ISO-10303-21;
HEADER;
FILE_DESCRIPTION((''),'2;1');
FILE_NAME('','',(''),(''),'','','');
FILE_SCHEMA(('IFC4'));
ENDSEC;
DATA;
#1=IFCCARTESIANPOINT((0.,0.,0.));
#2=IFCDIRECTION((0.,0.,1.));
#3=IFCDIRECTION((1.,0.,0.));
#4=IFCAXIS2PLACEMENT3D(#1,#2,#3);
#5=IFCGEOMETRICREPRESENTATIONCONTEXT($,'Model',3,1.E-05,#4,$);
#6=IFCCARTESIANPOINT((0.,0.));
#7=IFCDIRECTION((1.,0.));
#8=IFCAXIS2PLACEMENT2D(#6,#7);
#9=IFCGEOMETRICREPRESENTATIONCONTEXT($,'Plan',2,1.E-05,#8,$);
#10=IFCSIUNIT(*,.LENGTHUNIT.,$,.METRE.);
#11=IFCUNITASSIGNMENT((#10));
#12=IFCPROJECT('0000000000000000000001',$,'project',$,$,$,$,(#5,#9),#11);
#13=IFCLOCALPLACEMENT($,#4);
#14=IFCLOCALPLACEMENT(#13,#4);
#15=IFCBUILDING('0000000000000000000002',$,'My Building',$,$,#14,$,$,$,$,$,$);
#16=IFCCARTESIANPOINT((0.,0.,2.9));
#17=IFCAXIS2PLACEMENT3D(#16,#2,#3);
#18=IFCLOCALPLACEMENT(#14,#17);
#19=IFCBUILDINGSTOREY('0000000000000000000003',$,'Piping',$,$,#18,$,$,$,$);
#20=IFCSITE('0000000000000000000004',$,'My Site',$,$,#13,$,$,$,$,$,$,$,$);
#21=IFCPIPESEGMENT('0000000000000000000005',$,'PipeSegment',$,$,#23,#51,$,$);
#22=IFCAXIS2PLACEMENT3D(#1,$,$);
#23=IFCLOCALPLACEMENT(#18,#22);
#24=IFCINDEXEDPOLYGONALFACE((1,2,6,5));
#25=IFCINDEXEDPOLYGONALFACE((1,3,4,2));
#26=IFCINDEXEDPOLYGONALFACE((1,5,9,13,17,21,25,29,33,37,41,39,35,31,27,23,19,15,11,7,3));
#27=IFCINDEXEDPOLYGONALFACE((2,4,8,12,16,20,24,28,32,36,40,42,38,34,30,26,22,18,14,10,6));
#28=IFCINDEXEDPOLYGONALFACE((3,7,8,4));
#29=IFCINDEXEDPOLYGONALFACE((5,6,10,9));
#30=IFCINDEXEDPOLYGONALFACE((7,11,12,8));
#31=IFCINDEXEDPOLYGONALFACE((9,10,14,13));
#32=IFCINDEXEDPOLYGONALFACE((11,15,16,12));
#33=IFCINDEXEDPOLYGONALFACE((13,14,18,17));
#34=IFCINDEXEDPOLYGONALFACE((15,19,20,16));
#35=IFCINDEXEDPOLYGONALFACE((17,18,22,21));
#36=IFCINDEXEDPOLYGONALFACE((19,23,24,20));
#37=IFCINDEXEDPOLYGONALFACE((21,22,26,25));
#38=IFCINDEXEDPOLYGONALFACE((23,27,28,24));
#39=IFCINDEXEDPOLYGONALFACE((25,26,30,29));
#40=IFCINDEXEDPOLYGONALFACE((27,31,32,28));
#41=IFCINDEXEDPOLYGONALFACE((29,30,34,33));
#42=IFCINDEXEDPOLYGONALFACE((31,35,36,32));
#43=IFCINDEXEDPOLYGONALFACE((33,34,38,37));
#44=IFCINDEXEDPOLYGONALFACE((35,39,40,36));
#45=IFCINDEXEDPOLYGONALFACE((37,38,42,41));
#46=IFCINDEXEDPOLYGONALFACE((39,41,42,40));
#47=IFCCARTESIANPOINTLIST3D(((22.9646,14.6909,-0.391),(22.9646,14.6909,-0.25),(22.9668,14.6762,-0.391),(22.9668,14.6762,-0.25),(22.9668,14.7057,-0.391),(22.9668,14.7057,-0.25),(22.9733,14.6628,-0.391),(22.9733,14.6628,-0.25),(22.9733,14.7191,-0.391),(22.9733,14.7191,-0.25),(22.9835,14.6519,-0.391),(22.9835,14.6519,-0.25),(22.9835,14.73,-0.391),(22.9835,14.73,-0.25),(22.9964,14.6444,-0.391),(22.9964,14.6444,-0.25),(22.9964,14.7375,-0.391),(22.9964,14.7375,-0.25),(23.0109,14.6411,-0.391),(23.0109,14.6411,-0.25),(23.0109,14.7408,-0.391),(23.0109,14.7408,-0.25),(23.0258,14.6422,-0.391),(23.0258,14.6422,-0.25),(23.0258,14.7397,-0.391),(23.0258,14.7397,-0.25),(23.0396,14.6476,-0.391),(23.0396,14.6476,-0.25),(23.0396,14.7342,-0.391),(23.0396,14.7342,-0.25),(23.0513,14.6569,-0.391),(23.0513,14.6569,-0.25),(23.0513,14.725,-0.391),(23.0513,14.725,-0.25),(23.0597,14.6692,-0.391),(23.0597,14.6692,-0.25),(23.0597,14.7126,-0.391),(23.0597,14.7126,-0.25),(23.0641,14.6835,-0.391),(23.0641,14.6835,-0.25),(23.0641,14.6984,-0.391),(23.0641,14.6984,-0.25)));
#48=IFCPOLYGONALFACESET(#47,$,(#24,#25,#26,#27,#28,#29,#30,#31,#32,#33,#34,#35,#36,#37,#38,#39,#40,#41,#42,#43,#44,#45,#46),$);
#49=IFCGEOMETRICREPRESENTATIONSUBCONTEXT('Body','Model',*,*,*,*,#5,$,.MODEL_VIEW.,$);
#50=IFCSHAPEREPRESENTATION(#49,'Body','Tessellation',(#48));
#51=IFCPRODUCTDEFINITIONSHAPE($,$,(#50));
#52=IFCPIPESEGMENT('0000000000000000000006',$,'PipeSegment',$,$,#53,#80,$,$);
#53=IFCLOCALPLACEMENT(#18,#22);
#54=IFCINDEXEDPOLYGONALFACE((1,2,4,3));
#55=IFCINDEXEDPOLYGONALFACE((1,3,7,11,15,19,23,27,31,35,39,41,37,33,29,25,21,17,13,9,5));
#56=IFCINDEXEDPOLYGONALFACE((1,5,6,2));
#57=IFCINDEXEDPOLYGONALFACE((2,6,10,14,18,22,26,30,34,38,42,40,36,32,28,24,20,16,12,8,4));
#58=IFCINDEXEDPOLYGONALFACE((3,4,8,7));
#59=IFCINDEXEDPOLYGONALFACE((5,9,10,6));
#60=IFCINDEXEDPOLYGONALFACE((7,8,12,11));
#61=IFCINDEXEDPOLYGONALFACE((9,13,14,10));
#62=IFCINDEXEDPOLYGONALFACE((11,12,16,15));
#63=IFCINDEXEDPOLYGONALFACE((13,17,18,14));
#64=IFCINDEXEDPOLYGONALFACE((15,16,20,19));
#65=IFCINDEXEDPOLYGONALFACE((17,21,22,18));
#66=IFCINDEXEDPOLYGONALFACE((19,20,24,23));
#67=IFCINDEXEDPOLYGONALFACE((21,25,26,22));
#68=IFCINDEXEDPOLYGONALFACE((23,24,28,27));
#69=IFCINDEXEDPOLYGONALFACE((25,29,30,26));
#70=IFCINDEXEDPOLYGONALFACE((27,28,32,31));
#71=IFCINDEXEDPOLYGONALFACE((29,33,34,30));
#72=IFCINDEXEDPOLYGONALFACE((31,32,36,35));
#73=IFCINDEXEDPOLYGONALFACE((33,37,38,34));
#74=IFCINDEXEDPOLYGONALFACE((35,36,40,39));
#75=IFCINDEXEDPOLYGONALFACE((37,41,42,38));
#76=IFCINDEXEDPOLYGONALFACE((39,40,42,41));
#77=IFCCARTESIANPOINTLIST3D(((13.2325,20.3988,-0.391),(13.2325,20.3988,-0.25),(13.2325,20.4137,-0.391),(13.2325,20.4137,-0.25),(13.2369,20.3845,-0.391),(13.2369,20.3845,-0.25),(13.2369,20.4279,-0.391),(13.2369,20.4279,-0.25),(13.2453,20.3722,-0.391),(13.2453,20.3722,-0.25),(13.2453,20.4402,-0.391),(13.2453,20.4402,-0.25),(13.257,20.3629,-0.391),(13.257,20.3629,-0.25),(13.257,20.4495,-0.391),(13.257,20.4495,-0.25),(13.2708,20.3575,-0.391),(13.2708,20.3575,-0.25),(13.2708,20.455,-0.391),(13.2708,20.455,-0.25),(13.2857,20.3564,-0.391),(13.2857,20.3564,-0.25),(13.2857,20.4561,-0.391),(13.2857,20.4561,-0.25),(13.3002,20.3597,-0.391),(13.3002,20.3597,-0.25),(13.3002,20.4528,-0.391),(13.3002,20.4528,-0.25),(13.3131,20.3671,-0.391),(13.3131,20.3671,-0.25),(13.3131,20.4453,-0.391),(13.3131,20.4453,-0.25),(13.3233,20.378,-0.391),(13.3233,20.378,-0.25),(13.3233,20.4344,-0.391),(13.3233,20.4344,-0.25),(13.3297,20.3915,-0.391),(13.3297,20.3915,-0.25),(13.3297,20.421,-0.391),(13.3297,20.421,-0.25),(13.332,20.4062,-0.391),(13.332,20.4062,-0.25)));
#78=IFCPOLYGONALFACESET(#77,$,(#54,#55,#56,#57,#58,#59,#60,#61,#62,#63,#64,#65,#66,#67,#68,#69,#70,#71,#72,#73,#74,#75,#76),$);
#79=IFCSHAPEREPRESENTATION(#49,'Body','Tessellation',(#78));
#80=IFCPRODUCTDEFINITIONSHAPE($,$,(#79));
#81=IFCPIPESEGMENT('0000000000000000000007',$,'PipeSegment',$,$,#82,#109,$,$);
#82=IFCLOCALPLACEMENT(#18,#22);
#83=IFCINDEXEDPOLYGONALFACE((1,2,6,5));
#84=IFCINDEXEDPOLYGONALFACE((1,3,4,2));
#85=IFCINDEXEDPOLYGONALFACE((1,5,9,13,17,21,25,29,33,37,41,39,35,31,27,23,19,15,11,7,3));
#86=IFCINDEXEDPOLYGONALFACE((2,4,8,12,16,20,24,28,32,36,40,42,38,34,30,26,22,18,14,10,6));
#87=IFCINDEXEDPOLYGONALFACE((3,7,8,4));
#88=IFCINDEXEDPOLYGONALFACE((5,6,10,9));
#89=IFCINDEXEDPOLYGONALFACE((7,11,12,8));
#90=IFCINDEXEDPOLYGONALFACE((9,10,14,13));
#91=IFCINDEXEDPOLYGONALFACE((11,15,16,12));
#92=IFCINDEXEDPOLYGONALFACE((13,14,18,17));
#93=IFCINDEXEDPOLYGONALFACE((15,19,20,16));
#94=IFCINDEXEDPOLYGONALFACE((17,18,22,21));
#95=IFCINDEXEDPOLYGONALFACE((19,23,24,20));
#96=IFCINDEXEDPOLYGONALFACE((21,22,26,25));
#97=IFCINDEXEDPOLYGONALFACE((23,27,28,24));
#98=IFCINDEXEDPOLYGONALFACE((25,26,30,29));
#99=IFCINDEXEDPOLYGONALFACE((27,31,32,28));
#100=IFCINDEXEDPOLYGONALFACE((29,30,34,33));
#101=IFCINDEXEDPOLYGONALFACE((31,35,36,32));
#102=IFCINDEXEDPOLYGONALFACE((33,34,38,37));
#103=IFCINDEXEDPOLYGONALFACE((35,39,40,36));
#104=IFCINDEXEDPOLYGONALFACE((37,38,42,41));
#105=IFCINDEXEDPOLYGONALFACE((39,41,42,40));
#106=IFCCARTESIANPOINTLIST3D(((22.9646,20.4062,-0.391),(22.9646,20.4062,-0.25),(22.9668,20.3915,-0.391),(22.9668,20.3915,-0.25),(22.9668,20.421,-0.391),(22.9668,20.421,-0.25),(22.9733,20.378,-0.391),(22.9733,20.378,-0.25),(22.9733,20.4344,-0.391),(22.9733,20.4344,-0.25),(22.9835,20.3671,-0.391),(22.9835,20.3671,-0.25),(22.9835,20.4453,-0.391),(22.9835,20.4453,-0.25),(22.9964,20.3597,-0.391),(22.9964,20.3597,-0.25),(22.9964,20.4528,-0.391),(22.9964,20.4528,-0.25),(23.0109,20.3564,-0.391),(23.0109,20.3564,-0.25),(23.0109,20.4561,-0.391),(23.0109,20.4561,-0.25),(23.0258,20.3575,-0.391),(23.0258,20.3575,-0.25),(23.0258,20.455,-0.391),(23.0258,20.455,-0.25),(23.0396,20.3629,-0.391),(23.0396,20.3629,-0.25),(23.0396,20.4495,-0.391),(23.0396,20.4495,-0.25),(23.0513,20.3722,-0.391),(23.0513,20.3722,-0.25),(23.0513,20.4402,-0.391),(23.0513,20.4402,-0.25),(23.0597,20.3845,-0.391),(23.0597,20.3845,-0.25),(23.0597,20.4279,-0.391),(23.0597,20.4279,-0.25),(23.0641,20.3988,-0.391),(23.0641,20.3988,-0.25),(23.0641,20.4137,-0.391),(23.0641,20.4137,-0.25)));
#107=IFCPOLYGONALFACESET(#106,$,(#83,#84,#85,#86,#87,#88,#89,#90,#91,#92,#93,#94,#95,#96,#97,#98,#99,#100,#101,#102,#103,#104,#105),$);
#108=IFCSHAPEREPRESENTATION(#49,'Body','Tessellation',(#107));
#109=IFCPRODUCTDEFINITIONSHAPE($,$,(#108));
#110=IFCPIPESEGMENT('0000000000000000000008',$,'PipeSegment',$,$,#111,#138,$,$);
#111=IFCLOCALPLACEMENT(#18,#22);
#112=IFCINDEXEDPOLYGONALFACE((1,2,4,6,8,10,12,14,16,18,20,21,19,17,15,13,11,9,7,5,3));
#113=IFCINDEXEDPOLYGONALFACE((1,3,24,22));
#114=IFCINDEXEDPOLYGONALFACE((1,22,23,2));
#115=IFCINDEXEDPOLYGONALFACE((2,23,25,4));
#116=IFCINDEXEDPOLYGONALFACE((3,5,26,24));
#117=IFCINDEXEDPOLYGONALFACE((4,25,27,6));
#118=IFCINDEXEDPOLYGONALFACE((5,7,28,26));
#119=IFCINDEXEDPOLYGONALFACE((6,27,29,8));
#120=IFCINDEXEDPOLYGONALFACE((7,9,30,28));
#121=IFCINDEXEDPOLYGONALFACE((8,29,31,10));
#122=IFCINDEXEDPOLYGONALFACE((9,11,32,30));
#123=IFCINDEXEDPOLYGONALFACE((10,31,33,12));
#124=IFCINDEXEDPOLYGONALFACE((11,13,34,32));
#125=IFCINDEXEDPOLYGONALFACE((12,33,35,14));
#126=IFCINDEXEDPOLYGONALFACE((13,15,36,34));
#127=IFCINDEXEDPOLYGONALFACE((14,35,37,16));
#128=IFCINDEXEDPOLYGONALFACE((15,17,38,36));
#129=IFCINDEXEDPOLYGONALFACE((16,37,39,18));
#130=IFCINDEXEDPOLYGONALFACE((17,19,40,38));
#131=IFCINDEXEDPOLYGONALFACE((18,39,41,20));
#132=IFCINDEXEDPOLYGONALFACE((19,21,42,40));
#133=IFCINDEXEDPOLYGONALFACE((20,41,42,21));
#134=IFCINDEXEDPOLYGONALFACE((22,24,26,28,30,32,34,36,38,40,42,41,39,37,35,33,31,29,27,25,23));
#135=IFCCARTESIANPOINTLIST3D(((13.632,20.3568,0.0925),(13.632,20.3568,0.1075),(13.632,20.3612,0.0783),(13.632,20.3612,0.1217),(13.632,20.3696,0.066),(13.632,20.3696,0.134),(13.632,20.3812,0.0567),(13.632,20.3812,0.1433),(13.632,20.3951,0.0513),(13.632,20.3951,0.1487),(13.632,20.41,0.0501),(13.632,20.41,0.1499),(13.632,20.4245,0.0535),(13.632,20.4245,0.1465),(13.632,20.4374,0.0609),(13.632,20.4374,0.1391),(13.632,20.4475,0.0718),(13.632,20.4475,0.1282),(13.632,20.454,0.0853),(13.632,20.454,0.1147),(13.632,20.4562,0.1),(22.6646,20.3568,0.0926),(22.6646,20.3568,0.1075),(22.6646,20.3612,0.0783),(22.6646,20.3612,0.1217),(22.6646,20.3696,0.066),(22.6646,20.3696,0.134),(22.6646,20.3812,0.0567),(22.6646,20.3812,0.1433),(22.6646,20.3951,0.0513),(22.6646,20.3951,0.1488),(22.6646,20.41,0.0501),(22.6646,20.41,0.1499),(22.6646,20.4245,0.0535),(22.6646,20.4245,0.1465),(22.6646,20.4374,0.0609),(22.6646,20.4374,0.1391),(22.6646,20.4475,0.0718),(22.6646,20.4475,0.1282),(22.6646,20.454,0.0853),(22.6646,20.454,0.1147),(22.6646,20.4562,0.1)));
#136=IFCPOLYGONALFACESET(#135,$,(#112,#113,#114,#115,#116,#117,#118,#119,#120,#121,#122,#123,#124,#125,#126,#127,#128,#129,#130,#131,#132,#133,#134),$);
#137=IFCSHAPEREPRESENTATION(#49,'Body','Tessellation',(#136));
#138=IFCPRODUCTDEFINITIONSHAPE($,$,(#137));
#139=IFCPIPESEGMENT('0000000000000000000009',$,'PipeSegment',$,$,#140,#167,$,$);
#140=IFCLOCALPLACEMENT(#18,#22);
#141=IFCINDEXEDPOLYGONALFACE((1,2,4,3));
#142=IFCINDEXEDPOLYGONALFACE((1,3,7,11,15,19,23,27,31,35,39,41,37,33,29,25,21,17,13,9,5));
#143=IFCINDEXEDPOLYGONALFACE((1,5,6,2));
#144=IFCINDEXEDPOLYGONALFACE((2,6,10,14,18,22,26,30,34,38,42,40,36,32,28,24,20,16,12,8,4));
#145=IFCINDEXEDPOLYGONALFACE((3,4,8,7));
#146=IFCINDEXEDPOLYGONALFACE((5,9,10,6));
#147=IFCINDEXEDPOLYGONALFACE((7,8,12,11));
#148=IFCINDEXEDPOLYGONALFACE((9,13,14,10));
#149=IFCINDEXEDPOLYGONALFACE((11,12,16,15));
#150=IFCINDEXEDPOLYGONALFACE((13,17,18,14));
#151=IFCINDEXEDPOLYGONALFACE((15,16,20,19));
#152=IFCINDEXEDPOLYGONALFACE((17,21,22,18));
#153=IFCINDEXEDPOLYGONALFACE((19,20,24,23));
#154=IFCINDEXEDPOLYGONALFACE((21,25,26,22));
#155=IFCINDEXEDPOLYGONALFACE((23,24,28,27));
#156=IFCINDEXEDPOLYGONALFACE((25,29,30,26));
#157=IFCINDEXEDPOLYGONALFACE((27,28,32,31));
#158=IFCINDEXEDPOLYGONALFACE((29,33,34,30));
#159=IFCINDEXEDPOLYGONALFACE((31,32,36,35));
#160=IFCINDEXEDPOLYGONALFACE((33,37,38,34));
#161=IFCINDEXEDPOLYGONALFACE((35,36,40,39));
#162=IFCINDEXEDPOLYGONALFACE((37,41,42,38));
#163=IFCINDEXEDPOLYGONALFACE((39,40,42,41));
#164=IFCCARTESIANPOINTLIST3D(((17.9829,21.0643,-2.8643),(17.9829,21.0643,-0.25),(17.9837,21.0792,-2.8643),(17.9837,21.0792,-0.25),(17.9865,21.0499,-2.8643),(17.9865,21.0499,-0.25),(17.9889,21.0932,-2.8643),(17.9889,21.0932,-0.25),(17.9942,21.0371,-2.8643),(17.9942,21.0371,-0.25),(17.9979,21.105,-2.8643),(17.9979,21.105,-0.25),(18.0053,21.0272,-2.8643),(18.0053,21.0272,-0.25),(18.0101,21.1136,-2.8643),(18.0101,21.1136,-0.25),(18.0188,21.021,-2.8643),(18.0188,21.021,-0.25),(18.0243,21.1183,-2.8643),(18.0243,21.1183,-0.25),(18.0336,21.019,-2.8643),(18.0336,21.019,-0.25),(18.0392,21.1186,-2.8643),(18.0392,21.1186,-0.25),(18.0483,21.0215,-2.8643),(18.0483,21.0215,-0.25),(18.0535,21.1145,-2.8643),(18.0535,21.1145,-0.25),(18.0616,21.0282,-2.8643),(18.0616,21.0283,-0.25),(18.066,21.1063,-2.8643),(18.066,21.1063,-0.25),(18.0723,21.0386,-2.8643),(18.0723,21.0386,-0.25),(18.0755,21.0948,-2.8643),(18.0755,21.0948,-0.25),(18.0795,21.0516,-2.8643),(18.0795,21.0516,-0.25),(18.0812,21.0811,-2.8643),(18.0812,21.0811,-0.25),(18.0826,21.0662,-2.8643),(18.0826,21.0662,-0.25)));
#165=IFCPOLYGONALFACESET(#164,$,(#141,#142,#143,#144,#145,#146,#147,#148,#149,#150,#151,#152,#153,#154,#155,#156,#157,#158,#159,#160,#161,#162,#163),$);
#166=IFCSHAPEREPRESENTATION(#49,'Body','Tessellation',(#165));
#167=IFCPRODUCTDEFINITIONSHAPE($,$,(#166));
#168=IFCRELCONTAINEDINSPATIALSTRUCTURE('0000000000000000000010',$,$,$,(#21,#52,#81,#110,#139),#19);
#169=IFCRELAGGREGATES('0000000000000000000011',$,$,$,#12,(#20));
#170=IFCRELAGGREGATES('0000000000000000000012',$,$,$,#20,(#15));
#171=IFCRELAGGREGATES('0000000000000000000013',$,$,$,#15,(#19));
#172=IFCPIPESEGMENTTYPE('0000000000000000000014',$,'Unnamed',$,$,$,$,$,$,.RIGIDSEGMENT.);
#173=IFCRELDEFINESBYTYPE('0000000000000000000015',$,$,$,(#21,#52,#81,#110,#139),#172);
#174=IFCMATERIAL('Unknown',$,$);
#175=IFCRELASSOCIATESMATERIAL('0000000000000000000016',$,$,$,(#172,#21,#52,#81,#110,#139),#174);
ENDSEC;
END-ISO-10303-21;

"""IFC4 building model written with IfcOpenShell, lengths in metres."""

from ifc_helpers import new_model, si_unit, frame, origin_with_axes, origin_2d_with_axis, place, context, subcontext, project, spatial, circle, extrude, material, material_profile, profile_set, profile_usage, type_object, element, save


model = new_model("IFC4")

# Units and contexts
model_context = context("Model", 3, precision=1e-05, world=origin_with_axes())
plan_context = context("Plan", 2, precision=1e-05, world=origin_2d_with_axis())
body_context = subcontext(model_context, "Body", "Model", "MODEL_VIEW")
ifc_project = project(units=[si_unit("LENGTHUNIT", "METRE")], contexts=[model_context, plan_context])

# Site, building, storey
site_placement = place(None, origin_with_axes())
site = spatial("IfcSite", under=ifc_project, at=site_placement, Name="My Site")
building_placement = place(site_placement, origin_with_axes())
building = spatial("IfcBuilding", under=site, at=building_placement, Name="My Building")
storey_placement = place(building_placement, frame((0.0, 0.0, 2.9), z_axis=(0.0, 0.0, 1.0), x_axis=(1.0, 0.0, 0.0)))
storey = spatial("IfcBuildingStorey", under=building, at=storey_placement, Name="Piping")

# Pipe segments
ifc_material = material(Name="Unknown")
ifc_material_profile = material_profile(ifc_material, circle(Radius=0.05))
ifc_profile_set = profile_set([ifc_material_profile])
pipe_segment_type = type_object("IfcPipeSegmentType", Name="Unnamed", PredefinedType="RIGIDSEGMENT", material=ifc_profile_set)
ifc_profile_usage_1 = profile_usage(ifc_profile_set, cardinal=5)
pipe_segment_1_placement = place(storey_placement, frame((23.0146, 14.6909, -0.25), z_axis=(0.0, 0.0, -1.0), x_axis=(-1.0, 0.0, 0.0)))
element("IfcPipeSegment", 1, at=pipe_segment_1_placement, inside=storey, type_object=pipe_segment_type, material=ifc_profile_usage_1, Name="PipeSegment", context=body_context, shape_type="SweptSolid", body=[
    extrude(circle(Radius=0.05), origin_with_axes(), (0.0, 0.0, 1.0), 0.141),
])
ifc_profile_usage_2 = profile_usage(ifc_profile_set, cardinal=5)
pipe_segment_2_placement = place(storey_placement, frame((13.282, 20.4062, -0.25), z_axis=(0.0, 0.0, -1.0), x_axis=(1.0, 0.0, 0.0)))
element("IfcPipeSegment", 2, at=pipe_segment_2_placement, inside=storey, type_object=pipe_segment_type, material=ifc_profile_usage_2, Name="PipeSegment", context=body_context, shape_type="SweptSolid", body=[
    extrude(circle(Radius=0.05), origin_with_axes(), (0.0, 0.0, 1.0), 0.141),
])
ifc_profile_usage_3 = profile_usage(ifc_profile_set, cardinal=5)
pipe_segment_3_placement = place(storey_placement, frame((23.0146, 20.4062, -0.25), z_axis=(0.0, 0.0, -1.0), x_axis=(-1.0, 0.0, 0.0)))
element("IfcPipeSegment", 3, at=pipe_segment_3_placement, inside=storey, type_object=pipe_segment_type, material=ifc_profile_usage_3, Name="PipeSegment", context=body_context, shape_type="SweptSolid", body=[
    extrude(circle(Radius=0.05), origin_with_axes(), (0.0, 0.0, 1.0), 0.141),
])
ifc_profile_usage_4 = profile_usage(ifc_profile_set, cardinal=5)
pipe_segment_4_placement = place(storey_placement, frame((13.632, 20.4062, 0.1), z_axis=(1.0, -0.000001, 0.000001), x_axis=(0.000001, 1.0, 0.0)))
element("IfcPipeSegment", 4, at=pipe_segment_4_placement, inside=storey, type_object=pipe_segment_type, material=ifc_profile_usage_4, Name="PipeSegment", context=body_context, shape_type="SweptSolid", body=[
    extrude(circle(Radius=0.05), origin_with_axes(), (0.0, 0.0, 1.0), 9.0327),
])
ifc_profile_usage_5 = profile_usage(ifc_profile_set, cardinal=5)
pipe_segment_5_placement = place(storey_placement, frame((18.0327, 21.069, -0.25), z_axis=(-0.000001, -0.000001, -1.0), x_axis=(-0.547332, -0.836916, 0.000001)))
element("IfcPipeSegment", 5, at=pipe_segment_5_placement, inside=storey, type_object=pipe_segment_type, material=ifc_profile_usage_5, Name="PipeSegment", context=body_context, shape_type="SweptSolid", body=[
    extrude(circle(Radius=0.05), origin_with_axes(), (0.0, 0.0, 1.0), 2.6143),
])

save(model, "model.ifc")
